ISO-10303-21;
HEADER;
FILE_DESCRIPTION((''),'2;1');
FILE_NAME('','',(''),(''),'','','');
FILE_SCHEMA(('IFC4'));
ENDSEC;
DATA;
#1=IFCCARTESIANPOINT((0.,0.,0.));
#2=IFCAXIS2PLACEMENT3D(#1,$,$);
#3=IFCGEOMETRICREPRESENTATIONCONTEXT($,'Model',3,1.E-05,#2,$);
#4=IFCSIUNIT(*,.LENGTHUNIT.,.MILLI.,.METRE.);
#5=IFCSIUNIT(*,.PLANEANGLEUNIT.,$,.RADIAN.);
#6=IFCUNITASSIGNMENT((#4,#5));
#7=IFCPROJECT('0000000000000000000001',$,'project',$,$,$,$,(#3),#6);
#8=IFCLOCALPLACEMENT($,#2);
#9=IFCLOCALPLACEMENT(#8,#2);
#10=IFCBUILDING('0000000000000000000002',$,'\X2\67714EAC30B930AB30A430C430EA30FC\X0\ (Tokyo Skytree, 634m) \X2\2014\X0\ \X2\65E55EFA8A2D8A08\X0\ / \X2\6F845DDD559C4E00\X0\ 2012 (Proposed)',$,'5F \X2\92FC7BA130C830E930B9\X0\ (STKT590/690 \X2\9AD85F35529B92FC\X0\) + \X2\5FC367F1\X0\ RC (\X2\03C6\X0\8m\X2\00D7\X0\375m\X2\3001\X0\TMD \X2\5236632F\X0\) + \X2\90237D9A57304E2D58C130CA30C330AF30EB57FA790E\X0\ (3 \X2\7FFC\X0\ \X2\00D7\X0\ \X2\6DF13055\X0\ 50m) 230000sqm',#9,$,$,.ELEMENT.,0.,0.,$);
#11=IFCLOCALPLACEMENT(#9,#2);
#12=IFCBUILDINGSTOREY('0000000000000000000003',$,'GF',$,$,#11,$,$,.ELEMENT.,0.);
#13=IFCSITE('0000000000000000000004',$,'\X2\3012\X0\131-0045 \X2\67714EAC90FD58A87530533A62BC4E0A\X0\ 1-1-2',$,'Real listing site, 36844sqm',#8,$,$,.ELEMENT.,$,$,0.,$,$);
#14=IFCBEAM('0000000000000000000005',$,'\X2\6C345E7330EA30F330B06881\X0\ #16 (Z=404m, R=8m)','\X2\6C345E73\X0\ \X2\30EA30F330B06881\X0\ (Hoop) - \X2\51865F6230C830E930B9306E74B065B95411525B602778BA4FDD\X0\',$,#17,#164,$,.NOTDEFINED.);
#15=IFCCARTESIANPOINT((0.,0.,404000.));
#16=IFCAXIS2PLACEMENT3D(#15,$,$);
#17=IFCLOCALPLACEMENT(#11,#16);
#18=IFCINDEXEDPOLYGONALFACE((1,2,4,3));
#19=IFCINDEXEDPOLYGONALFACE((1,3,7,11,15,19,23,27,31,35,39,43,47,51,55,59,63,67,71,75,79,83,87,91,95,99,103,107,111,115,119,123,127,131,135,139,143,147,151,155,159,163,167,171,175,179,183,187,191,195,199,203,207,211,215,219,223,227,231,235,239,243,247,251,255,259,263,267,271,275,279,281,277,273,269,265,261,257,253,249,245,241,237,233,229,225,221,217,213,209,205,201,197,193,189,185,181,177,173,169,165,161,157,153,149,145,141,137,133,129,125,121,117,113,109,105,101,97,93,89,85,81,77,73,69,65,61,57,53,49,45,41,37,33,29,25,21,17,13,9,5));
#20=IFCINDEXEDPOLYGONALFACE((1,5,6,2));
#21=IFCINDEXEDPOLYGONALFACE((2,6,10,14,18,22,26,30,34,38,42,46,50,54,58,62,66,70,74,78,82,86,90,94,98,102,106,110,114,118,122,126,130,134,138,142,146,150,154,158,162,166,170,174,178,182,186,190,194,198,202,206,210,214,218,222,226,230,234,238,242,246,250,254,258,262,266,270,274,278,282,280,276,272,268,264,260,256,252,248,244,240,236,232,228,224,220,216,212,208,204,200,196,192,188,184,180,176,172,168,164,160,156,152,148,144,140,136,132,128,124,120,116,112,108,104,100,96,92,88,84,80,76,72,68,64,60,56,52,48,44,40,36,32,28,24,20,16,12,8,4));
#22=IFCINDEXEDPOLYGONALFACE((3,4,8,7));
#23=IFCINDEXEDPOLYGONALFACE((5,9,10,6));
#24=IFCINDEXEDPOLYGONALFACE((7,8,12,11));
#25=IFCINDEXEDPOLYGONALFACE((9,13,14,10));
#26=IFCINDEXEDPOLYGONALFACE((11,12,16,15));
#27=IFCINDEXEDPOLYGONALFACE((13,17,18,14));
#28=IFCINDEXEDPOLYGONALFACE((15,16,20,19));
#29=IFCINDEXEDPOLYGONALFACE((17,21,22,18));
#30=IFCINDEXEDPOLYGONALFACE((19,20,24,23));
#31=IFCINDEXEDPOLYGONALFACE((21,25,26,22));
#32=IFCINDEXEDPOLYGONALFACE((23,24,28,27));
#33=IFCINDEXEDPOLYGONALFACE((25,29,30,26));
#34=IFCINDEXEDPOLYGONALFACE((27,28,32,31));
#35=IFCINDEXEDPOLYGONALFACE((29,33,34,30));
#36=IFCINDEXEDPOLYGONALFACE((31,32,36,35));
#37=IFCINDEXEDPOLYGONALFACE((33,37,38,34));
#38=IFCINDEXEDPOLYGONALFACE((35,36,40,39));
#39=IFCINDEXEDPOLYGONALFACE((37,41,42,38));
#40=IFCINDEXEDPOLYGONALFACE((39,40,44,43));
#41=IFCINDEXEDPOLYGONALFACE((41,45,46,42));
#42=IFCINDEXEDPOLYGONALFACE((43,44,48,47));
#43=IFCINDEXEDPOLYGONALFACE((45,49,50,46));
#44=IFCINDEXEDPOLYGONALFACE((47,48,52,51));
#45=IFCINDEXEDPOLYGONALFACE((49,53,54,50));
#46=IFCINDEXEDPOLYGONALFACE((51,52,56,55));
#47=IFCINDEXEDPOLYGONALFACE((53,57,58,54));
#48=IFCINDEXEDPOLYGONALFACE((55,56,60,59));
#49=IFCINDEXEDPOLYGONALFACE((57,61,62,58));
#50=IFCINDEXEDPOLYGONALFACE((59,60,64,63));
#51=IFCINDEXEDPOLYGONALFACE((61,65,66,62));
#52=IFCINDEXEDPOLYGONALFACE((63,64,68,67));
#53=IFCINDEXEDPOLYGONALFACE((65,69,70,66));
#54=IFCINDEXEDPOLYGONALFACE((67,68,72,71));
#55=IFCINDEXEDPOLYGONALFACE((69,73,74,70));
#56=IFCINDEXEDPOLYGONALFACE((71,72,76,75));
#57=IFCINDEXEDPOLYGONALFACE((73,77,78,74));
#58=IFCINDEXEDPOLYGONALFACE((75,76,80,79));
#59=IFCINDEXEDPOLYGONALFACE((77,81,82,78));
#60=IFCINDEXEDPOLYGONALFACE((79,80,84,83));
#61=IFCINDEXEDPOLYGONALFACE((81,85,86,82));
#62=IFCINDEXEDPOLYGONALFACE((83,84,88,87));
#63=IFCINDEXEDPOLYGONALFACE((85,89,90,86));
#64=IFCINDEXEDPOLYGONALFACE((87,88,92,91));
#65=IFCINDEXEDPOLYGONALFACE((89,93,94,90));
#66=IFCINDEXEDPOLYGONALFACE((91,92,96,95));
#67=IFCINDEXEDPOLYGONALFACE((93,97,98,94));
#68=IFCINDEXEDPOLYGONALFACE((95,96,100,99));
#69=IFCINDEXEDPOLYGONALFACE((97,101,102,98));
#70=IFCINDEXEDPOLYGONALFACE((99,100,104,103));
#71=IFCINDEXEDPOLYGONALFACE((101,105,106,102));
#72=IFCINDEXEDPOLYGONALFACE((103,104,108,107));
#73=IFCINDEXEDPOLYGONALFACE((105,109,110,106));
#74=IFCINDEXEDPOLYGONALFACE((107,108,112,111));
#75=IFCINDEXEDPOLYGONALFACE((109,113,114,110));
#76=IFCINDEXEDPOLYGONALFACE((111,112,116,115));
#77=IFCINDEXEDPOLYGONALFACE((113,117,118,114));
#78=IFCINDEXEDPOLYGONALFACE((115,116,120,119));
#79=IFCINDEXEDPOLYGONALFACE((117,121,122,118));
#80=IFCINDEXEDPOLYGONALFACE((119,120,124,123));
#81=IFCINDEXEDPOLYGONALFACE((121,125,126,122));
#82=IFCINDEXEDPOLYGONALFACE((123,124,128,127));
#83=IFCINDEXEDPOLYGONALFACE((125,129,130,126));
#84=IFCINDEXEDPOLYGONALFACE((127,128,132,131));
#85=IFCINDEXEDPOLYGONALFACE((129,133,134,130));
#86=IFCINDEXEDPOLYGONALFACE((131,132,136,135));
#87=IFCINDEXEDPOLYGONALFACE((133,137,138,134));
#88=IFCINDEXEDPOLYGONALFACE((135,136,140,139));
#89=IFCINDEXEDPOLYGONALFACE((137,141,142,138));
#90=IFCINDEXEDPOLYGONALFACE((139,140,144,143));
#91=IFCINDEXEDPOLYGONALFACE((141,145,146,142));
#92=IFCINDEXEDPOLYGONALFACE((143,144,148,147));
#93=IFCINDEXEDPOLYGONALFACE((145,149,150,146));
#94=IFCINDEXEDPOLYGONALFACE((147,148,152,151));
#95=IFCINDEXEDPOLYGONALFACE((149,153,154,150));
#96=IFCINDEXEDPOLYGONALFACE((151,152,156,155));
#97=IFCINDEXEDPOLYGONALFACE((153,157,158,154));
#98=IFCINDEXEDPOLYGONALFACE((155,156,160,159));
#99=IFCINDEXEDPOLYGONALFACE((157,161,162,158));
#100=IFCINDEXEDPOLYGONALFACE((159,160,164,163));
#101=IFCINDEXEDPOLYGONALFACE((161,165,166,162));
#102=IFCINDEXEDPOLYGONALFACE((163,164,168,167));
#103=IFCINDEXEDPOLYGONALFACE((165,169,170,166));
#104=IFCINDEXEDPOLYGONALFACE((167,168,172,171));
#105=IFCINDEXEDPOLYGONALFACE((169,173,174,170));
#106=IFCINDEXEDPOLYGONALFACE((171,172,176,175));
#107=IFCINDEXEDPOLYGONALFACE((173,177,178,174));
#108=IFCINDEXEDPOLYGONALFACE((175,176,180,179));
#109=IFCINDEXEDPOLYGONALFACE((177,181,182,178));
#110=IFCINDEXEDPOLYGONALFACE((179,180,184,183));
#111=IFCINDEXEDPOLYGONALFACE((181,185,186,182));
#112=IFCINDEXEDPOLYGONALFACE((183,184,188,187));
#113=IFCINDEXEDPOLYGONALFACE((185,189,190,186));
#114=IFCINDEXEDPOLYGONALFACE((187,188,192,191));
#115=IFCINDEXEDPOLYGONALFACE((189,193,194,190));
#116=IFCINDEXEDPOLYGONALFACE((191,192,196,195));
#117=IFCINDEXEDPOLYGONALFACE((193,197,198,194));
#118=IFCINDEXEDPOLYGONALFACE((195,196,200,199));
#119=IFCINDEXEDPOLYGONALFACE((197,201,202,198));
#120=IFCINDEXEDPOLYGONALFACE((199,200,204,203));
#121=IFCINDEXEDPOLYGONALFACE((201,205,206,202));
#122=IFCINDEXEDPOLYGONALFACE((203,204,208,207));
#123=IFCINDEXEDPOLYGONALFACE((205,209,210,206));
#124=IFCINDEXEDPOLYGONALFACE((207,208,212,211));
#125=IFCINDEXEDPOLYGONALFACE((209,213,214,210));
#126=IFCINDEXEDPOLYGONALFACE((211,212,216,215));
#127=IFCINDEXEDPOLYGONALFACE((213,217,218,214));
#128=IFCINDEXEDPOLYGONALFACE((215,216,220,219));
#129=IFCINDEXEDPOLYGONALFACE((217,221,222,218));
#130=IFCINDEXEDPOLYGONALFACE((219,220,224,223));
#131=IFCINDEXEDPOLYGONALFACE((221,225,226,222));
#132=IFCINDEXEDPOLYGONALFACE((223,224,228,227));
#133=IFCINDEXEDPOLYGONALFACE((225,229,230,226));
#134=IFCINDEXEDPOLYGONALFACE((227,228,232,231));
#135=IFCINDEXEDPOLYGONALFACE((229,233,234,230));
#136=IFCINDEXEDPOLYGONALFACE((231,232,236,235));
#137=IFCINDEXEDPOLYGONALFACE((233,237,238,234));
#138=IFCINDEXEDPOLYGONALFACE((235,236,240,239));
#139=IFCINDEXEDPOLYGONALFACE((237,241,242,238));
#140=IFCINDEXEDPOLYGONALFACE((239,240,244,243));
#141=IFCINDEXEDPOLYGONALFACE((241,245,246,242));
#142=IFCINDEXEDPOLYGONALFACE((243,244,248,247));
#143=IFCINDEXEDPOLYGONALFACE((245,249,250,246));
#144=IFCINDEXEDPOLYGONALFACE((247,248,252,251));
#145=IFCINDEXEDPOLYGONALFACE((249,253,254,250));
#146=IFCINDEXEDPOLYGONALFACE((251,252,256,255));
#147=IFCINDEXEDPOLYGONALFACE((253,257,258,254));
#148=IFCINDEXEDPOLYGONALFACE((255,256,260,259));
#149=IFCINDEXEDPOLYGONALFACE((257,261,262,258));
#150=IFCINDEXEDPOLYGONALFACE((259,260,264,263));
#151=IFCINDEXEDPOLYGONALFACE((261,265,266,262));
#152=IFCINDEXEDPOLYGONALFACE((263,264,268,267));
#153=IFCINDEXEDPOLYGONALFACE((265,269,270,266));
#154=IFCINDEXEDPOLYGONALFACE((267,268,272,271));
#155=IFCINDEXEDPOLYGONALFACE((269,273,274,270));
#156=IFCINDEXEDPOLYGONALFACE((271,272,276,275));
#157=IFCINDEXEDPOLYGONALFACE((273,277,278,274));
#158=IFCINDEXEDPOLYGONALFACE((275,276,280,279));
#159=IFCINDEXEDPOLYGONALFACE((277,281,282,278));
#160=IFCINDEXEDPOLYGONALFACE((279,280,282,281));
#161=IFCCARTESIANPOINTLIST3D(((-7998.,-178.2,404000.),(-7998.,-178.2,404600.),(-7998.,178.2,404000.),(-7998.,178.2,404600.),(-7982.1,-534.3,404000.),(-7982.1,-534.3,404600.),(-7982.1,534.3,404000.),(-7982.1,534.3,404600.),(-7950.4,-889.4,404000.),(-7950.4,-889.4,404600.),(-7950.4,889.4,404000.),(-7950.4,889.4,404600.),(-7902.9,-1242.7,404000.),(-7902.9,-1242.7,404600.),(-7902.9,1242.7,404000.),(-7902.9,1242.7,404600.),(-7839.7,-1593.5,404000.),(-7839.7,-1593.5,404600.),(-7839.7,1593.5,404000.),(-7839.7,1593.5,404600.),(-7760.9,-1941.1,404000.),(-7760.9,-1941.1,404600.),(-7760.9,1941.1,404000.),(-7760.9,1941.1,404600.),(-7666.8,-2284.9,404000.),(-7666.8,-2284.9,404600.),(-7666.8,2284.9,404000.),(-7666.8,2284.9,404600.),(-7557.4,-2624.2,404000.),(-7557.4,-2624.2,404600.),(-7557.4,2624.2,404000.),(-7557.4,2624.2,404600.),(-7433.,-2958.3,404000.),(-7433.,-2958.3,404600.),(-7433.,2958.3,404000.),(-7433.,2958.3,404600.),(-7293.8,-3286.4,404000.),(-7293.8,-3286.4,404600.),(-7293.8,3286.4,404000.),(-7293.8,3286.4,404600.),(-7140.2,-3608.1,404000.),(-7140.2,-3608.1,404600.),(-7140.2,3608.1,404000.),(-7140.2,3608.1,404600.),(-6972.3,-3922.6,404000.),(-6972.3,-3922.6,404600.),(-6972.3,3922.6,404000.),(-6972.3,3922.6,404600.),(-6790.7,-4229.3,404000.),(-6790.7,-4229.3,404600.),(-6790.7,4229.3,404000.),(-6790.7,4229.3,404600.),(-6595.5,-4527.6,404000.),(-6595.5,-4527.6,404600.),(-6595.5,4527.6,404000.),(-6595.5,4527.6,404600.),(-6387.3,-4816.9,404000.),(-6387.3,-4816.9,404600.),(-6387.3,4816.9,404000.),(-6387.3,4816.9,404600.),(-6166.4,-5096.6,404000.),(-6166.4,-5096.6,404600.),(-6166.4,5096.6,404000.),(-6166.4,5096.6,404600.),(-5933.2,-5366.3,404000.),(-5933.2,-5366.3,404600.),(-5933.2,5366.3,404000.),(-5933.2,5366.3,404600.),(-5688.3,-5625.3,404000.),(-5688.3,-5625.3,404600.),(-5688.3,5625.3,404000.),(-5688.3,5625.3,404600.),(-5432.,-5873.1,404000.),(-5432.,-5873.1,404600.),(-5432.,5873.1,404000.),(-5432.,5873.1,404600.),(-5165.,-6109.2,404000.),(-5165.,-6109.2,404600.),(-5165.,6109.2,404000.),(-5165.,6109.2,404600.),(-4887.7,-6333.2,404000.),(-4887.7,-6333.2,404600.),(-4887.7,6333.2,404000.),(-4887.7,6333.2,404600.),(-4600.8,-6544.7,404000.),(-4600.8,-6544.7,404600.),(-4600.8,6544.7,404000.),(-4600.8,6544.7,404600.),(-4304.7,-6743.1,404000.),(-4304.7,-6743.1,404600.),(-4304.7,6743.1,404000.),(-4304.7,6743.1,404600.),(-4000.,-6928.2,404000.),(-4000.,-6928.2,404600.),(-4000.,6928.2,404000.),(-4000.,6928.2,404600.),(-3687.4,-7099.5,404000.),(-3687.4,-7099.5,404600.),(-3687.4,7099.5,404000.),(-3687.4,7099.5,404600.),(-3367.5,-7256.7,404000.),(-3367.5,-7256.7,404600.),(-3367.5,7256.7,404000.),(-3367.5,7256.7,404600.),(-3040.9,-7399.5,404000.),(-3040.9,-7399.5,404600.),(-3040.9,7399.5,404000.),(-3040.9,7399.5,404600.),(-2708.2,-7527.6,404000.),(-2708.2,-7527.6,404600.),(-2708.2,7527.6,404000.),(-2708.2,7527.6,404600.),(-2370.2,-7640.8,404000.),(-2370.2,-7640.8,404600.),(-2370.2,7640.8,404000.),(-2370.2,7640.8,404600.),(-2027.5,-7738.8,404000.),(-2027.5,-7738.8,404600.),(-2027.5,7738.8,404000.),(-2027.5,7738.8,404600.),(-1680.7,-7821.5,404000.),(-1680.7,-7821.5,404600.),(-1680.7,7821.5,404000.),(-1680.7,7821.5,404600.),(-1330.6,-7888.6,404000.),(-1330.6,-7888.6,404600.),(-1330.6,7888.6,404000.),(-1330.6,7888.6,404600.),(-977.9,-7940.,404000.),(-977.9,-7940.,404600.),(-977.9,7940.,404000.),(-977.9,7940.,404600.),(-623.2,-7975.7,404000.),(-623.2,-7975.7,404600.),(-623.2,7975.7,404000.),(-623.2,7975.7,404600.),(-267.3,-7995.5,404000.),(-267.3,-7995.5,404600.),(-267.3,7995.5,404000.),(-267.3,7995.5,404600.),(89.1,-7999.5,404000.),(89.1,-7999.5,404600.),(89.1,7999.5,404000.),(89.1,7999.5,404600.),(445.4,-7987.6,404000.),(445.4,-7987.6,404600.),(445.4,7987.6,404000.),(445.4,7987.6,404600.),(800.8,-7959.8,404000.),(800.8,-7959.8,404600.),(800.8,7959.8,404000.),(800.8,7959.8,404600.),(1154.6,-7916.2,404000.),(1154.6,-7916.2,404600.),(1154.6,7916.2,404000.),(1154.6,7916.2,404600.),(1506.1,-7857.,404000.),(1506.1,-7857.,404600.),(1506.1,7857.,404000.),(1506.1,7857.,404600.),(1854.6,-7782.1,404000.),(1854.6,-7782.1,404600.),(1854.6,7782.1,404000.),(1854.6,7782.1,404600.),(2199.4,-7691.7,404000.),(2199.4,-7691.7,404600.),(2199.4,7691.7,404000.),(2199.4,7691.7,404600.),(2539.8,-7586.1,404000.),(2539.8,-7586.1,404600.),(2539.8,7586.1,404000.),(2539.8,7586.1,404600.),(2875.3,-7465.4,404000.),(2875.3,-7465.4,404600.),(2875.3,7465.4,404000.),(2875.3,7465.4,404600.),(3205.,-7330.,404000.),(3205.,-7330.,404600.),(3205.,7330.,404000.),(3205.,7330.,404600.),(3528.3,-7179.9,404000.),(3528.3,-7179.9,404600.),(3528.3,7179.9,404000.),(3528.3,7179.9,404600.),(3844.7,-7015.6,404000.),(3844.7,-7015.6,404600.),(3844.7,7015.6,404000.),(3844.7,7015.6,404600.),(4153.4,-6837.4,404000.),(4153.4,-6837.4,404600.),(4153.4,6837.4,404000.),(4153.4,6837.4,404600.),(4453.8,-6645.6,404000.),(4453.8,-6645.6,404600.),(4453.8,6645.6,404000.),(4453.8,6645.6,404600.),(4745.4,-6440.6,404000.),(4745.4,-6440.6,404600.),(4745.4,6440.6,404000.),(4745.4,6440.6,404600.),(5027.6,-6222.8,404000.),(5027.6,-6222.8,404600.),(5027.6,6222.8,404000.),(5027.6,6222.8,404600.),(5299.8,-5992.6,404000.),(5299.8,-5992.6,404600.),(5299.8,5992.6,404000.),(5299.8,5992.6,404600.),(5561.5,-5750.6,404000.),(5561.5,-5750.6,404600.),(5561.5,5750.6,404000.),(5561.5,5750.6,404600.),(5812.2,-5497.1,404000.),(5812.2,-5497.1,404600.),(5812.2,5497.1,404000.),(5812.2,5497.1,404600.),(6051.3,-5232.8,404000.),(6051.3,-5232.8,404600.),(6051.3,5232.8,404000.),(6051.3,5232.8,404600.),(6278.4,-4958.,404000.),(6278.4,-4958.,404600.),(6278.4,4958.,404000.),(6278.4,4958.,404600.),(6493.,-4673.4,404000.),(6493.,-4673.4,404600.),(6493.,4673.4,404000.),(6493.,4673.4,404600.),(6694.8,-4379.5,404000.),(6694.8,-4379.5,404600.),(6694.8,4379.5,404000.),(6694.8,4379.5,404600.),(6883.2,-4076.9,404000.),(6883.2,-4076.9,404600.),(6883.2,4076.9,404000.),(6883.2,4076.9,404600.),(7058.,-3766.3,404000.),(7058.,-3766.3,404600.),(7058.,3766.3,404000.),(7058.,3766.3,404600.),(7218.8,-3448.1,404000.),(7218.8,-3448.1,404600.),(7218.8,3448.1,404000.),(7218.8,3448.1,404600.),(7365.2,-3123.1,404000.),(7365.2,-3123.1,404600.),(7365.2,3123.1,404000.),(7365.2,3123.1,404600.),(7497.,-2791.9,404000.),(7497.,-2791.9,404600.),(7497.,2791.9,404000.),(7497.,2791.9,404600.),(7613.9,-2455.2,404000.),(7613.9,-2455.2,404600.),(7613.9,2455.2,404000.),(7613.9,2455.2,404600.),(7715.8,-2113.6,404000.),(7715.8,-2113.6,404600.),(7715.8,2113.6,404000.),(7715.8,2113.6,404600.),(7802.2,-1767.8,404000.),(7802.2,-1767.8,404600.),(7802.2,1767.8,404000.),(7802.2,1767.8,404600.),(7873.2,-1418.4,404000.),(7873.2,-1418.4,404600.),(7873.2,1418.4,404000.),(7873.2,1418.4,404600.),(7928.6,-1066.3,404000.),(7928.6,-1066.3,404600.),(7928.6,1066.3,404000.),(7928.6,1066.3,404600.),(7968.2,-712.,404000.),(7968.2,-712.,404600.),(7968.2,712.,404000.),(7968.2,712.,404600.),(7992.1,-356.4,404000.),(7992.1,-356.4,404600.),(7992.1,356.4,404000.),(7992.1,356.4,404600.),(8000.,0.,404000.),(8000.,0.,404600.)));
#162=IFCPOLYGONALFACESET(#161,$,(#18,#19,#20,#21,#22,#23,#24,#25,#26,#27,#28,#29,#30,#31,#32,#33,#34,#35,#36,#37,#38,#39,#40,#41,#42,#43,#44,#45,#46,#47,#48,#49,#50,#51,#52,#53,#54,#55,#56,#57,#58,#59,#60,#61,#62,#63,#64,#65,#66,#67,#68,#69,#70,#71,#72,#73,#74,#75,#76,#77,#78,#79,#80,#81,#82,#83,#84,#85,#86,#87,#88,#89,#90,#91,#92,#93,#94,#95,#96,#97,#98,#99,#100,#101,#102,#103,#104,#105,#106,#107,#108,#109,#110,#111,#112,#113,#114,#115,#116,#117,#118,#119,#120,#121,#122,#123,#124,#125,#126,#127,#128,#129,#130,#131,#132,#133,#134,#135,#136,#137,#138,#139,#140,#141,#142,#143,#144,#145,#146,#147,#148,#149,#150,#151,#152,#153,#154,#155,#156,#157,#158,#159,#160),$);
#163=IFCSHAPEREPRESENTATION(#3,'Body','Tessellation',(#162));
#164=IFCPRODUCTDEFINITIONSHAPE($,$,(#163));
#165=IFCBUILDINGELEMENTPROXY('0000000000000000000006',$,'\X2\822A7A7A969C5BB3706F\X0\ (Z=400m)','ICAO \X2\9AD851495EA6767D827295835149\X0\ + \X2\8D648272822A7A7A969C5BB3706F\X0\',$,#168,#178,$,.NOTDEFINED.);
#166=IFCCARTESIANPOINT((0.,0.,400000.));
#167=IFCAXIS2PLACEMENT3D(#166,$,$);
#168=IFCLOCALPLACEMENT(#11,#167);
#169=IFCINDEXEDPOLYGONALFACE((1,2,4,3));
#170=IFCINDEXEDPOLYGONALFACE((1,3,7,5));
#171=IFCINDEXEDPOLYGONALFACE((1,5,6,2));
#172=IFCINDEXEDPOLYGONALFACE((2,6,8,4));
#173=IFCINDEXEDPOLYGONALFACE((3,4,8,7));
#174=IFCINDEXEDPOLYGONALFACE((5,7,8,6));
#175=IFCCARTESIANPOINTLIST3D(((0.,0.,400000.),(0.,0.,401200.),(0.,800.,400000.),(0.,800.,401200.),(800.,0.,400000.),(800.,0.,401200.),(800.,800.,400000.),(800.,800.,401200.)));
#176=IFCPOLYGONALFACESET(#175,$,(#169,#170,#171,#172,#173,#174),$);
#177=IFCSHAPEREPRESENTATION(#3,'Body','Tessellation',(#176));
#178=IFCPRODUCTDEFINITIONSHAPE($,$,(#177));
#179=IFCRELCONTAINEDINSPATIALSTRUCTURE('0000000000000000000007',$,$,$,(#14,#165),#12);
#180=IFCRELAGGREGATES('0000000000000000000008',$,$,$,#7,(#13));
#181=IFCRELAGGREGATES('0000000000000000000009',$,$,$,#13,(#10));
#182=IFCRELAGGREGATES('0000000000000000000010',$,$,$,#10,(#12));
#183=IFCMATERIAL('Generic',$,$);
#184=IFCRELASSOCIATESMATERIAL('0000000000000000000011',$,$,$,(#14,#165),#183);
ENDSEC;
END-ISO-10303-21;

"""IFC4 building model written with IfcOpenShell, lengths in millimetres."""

from ifc_helpers import new_model, si_unit, frame, frame_2d, origin, origin_2d, place, context, project, spatial, rectangle, circle, extrude, material, element, save


model = new_model("IFC4")

# Units and contexts
model_context = context("Model", 3, precision=1e-05, world=origin())
ifc_project = project(units=[si_unit("LENGTHUNIT", "METRE", prefix="MILLI"), si_unit("PLANEANGLEUNIT", "RADIAN")], contexts=[model_context])

# Site, building, storey
site_placement = place(None, origin())
site = spatial("IfcSite", under=ifc_project, at=site_placement, Name="〒131-0045 東京都墨田区押上 1-1-2", ObjectType="Real listing site, 36844sqm", CompositionType="ELEMENT", RefElevation=0.0)
building_placement = place(site_placement, origin())
building = spatial("IfcBuilding", under=site, at=building_placement, Name="東京スカイツリー (Tokyo Skytree, 634m) — 日建設計 / 澄川喜一 2012 (Proposed)", ObjectType="5F 鋼管トラス (STKT590/690 高張力鋼) + 心柱 RC (φ8m×375m、TMD 制振) + 連続地中壁ナックル基礎 (3 翼 × 深さ 50m) 230000sqm", CompositionType="ELEMENT", ElevationOfRefHeight=0.0, ElevationOfTerrain=0.0)
storey_placement = place(building_placement, origin())
storey = spatial("IfcBuildingStorey", under=building, at=storey_placement, Name="GF", CompositionType="ELEMENT", Elevation=0.0)

# Shared definitions
ifc_material_1 = material(Name="Generic")

# Beam
beam_1_placement = place(storey_placement, frame((0.0, 0.0, 404000.0)))
element("IfcBeam", 1, at=beam_1_placement, inside=storey, material=ifc_material_1, Name="水平リング梁 #16 (Z=404m, R=8m)", Description="水平 リング梁 (Hoop) - 円形トラスの環方向剛性確保", PredefinedType="NOTDEFINED", context=model_context, shape_type="SweptSolid", body=[
    extrude(circle(Radius=8000.0, at=origin_2d()), frame((0.0, 0.0, 404000.0)), (0.0, 0.0, 1.0), 600.0),
])

# Building element proxy
proxy_1_placement = place(storey_placement, frame((0.0, 0.0, 400000.0)))
element("IfcBuildingElementProxy", 2, at=proxy_1_placement, inside=storey, material=ifc_material_1, Name="航空障害灯 (Z=400m)", Description="ICAO 高光度白色閃光 + 赤色航空障害灯", PredefinedType="NOTDEFINED", context=model_context, shape_type="SweptSolid", body=[
    extrude(rectangle(XDim=800.0, YDim=800.0, at=frame_2d((400.0, 400.0))), frame((0.0, 0.0, 400000.0)), (0.0, 0.0, 1.0), 1200.0),
])

save(model, "model.ifc")
